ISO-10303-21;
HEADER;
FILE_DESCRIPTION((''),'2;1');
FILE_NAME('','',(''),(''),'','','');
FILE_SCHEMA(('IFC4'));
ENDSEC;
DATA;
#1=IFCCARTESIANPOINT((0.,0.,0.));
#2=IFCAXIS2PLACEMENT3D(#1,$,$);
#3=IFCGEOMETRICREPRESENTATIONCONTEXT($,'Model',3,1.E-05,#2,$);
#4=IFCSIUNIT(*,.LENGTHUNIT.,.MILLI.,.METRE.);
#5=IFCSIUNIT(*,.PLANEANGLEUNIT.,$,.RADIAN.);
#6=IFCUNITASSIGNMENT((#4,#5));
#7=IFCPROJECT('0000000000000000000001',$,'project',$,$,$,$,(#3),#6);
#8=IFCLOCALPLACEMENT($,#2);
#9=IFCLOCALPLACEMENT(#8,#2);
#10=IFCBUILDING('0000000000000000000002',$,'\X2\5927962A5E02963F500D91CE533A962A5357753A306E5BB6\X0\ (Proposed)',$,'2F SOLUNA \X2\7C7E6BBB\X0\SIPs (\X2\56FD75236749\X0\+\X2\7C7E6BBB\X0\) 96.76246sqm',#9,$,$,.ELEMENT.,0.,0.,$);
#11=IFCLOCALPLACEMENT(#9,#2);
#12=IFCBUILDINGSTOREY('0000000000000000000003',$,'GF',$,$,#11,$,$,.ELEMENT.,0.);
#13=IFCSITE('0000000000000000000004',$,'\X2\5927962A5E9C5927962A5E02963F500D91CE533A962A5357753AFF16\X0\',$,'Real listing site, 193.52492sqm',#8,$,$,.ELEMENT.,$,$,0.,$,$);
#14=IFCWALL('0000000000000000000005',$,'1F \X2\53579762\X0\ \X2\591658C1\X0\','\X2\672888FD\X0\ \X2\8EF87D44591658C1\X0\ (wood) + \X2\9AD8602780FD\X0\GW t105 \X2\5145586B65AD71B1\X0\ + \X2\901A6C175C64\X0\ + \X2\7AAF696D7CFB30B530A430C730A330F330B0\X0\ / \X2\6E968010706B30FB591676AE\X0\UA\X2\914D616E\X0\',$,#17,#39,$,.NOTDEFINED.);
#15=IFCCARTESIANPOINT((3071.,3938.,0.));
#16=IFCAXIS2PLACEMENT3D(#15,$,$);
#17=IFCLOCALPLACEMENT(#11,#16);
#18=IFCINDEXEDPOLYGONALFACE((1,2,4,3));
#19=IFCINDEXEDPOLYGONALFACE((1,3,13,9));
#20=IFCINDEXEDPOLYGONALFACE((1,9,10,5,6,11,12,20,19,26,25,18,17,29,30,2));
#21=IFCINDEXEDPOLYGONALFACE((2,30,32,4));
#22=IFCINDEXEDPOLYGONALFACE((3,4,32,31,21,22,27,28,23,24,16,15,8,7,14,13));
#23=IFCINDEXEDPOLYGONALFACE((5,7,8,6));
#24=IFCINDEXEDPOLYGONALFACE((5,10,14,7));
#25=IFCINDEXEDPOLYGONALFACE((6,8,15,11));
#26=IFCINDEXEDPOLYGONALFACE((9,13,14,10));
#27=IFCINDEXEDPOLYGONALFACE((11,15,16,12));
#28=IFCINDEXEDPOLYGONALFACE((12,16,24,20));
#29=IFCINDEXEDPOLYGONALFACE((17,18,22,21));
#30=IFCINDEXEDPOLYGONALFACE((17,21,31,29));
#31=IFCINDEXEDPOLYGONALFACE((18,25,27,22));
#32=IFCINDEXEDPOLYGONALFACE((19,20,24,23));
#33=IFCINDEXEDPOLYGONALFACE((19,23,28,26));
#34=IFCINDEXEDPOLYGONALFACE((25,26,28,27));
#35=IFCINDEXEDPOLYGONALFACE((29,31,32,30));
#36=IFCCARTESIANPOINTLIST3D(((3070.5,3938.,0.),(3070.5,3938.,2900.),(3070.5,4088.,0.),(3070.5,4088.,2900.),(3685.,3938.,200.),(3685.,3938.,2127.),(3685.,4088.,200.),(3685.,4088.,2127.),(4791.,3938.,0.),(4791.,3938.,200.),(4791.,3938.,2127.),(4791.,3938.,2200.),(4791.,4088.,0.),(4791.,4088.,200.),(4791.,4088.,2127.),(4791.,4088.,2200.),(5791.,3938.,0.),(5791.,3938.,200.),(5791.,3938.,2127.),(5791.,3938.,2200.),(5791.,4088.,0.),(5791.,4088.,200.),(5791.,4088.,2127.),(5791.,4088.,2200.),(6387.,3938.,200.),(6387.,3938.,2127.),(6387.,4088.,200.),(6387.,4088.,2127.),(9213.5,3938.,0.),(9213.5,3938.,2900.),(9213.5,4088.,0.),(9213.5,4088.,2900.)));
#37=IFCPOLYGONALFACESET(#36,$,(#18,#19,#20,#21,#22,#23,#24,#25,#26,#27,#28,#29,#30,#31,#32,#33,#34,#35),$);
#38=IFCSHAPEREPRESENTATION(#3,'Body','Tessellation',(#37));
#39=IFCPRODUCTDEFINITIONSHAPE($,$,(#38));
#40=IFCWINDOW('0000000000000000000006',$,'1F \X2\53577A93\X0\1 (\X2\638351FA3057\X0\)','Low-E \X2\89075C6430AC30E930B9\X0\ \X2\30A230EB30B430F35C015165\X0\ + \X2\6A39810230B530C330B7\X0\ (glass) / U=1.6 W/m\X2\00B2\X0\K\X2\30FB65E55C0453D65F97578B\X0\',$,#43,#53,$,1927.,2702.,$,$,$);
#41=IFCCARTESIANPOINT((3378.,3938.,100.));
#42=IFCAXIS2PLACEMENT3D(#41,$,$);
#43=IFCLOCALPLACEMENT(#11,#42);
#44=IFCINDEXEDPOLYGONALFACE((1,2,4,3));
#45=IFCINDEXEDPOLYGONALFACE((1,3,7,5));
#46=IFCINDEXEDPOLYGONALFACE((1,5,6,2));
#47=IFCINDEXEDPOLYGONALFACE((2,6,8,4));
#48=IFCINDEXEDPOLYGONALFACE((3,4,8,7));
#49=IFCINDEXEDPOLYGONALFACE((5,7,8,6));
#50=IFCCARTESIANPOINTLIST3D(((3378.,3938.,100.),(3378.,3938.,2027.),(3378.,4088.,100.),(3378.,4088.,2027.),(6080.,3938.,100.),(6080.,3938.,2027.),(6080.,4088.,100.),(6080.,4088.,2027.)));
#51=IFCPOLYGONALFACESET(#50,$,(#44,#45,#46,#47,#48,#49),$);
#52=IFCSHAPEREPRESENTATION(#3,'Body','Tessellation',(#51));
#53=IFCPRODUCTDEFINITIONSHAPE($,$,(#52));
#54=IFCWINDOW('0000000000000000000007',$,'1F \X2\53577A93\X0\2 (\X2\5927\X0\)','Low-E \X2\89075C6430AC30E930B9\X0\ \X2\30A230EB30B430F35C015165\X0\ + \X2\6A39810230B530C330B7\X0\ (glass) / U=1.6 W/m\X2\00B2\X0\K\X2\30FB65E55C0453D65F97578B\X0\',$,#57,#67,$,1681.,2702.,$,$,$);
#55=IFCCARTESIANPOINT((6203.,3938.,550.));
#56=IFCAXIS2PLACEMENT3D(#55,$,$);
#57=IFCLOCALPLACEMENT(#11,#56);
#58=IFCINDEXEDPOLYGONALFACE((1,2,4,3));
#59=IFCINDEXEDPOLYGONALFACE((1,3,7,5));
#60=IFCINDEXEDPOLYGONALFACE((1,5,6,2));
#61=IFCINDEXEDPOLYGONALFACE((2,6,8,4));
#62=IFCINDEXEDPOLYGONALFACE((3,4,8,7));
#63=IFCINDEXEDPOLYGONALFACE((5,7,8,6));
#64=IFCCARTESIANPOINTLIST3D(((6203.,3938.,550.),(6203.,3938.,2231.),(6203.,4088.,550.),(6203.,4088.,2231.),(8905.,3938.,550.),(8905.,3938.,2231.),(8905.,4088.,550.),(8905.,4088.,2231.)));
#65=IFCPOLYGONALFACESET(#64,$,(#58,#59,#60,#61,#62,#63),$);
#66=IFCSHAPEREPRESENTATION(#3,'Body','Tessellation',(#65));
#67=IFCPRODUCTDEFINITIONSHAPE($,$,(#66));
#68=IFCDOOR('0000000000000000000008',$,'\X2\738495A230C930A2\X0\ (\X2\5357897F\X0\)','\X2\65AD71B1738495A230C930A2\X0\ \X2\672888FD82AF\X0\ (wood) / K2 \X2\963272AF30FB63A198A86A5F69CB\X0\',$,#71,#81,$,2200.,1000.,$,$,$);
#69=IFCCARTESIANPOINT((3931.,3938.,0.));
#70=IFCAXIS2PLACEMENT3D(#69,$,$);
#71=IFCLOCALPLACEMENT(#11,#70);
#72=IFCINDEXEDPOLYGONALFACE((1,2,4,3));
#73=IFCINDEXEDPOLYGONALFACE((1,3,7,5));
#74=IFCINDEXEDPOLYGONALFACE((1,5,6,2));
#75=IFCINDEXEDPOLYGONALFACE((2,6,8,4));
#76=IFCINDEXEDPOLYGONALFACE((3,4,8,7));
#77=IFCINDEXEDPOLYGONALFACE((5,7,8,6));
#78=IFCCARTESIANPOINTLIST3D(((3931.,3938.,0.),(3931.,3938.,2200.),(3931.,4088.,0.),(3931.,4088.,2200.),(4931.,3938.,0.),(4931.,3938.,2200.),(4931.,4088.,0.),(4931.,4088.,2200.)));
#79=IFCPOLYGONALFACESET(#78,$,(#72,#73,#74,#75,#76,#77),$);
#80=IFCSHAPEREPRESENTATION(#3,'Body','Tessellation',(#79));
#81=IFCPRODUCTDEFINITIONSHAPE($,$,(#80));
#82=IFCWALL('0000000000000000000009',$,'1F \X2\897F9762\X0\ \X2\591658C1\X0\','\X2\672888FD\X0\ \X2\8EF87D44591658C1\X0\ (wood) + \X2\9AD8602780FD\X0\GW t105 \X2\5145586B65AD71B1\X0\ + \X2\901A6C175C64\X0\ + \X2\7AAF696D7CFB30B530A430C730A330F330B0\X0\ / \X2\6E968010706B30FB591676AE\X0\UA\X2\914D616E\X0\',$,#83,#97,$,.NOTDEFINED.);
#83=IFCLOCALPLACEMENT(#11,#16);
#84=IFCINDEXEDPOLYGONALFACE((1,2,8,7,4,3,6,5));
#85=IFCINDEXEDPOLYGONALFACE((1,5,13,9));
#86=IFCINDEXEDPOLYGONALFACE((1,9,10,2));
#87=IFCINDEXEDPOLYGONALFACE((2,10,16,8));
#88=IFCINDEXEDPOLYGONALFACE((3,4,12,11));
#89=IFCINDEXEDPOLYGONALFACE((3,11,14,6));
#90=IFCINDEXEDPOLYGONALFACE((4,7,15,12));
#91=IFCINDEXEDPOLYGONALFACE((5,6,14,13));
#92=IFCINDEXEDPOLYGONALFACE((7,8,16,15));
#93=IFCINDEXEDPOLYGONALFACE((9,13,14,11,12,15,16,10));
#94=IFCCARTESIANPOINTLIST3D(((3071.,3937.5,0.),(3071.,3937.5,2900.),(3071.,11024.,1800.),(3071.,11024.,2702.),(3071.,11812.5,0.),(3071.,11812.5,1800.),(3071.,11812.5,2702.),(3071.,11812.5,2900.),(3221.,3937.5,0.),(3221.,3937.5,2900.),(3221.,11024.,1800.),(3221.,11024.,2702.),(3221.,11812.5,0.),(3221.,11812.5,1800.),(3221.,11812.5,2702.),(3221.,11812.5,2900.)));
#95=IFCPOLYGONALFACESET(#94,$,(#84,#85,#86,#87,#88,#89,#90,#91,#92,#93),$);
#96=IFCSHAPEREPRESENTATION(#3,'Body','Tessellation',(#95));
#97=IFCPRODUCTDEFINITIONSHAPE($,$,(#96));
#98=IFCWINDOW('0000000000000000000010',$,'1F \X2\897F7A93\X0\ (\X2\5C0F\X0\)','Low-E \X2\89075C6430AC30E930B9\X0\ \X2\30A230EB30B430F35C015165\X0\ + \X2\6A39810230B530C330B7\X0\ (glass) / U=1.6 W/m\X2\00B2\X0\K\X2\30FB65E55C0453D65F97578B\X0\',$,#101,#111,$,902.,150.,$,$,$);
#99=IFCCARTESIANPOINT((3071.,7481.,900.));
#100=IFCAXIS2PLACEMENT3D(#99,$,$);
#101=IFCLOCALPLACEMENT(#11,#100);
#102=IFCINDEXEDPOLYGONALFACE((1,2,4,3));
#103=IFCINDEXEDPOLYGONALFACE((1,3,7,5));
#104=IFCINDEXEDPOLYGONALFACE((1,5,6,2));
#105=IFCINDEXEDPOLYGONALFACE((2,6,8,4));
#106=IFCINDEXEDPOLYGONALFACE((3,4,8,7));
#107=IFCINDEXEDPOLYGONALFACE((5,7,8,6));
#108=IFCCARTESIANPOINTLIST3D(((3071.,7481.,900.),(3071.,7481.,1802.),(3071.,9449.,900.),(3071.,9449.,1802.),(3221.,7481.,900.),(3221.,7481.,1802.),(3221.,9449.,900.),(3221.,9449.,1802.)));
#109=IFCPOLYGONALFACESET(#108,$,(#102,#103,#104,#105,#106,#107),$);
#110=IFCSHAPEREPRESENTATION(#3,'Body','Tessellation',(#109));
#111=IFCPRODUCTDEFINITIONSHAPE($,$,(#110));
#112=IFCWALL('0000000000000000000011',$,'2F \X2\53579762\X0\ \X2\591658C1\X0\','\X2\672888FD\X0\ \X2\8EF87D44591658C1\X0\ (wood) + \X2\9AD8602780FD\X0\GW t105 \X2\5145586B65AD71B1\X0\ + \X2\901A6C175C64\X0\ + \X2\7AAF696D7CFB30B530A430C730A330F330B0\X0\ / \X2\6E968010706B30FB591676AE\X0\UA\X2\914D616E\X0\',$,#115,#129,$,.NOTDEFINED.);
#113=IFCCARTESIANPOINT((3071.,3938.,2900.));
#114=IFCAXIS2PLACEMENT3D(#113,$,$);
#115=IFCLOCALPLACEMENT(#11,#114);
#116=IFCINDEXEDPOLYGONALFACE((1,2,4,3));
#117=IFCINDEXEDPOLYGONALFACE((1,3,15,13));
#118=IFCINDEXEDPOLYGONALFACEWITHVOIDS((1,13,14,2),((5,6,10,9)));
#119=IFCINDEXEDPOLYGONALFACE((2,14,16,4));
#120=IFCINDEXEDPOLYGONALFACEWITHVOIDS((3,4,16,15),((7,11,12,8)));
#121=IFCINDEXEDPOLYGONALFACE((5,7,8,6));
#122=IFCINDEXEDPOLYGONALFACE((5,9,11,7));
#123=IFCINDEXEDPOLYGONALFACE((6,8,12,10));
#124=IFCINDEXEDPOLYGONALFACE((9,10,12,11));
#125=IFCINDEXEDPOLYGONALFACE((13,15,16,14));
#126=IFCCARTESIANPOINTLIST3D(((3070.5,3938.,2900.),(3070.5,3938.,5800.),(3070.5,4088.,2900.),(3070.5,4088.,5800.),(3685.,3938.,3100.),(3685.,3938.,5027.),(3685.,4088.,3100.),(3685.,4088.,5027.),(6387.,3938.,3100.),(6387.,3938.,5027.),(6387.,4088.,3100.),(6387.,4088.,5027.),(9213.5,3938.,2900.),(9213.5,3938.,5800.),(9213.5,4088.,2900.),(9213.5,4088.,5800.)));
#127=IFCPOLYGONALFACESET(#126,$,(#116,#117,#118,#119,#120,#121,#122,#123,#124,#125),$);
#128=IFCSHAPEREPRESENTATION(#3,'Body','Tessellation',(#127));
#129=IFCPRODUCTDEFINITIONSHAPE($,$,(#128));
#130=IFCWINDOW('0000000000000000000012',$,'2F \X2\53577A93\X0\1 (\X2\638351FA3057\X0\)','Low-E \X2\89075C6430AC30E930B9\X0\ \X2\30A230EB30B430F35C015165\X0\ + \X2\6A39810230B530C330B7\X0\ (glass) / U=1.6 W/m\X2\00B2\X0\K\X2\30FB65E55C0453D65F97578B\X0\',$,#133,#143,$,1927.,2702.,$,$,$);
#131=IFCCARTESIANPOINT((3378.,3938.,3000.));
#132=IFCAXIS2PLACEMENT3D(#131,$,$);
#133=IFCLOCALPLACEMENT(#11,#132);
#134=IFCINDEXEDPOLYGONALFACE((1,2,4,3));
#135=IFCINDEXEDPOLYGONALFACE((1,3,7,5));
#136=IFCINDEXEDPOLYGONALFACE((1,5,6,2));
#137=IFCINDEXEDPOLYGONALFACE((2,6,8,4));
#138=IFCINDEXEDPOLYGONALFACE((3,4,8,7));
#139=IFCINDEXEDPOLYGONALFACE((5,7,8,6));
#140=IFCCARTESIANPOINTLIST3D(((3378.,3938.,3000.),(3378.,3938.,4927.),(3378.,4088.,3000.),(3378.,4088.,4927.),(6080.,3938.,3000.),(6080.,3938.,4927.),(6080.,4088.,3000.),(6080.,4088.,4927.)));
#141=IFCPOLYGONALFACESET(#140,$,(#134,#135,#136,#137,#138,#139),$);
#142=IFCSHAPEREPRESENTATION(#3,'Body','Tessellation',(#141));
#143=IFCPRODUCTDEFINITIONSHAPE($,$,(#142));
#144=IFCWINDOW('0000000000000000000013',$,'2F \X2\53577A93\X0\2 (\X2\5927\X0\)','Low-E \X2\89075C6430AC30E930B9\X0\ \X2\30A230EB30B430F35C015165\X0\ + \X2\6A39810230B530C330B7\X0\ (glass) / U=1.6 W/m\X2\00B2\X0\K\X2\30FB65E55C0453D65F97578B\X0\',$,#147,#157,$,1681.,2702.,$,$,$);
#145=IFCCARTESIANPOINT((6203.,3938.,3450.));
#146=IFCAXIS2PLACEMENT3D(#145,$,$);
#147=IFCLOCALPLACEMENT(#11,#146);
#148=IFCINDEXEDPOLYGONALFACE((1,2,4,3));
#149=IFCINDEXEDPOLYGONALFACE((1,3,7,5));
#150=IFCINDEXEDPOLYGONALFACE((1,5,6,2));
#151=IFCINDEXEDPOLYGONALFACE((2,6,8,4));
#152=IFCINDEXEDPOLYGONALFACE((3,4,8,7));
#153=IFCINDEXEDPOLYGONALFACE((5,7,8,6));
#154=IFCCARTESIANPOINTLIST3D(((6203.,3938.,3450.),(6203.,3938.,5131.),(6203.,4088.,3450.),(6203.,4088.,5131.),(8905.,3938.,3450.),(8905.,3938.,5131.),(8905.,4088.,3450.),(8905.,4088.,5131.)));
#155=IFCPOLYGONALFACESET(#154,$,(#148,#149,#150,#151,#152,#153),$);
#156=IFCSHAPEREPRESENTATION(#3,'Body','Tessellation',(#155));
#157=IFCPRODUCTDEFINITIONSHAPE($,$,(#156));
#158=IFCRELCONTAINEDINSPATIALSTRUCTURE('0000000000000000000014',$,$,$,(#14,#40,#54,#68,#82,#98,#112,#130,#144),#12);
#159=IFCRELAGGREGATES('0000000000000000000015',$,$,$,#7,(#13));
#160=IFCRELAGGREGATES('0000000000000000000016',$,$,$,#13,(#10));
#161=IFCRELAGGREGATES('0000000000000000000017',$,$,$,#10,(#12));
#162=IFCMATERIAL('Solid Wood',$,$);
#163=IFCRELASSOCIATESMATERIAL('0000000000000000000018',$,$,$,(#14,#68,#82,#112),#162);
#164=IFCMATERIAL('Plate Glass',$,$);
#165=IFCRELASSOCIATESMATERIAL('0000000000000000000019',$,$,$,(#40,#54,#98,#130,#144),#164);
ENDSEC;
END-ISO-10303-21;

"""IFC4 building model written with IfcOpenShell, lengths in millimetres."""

from ifc_helpers import new_model, si_unit, frame, frame_2d, origin, place, context, project, spatial, rectangle, extrude, material, element, fill, save


model = new_model("IFC4")

# Units and contexts
model_context = context("Model", 3, precision=1e-05, world=origin())
ifc_project = project(units=[si_unit("LENGTHUNIT", "METRE", prefix="MILLI"), si_unit("PLANEANGLEUNIT", "RADIAN")], contexts=[model_context])

# Site, building, storey
site_placement = place(None, origin())
site = spatial("IfcSite", under=ifc_project, at=site_placement, Name="大阪府大阪市阿倍野区阪南町６", ObjectType="Real listing site, 193.52492sqm", CompositionType="ELEMENT", RefElevation=0.0)
building_placement = place(site_placement, origin())
building = spatial("IfcBuilding", under=site, at=building_placement, Name="大阪市阿倍野区阪南町の家 (Proposed)", ObjectType="2F SOLUNA 籾殻SIPs (国産杉+籾殻) 96.76246sqm", CompositionType="ELEMENT", ElevationOfRefHeight=0.0, ElevationOfTerrain=0.0)
storey_placement = place(building_placement, origin())
storey = spatial("IfcBuildingStorey", under=building, at=storey_placement, Name="GF", CompositionType="ELEMENT", Elevation=0.0)

# Shared definitions
ifc_material_1 = material(Name="Solid Wood")

# Wall, openings, windows, door
wall_1_placement = place(storey_placement, frame((3071.0, 3938.0, 0.0)))
wall_1 = element("IfcWall", 1, at=wall_1_placement, inside=storey, material=ifc_material_1, Name="1F 南面 外壁", Description="木製 軸組外壁 (wood) + 高性能GW t105 充填断熱 + 通気層 + 窯業系サイディング / 準耐火・外皮UA配慮", PredefinedType="NOTDEFINED", context=model_context, shape_type="SweptSolid", body=[
    extrude(rectangle(XDim=6143.0, YDim=150.0, at=frame_2d((3071.0, 75.0))), frame((3071.0, 3938.0, 0.0)), (0.0, 0.0, 1.0), 2900.0),
])
opening_1_placement = place(storey_placement, frame((3378.0, 3938.0, 100.0)))
opening_1 = element("IfcOpeningElement", 2, at=opening_1_placement, cuts=wall_1, PredefinedType="NOTDEFINED", context=model_context, shape_type="SweptSolid", body=[
    extrude(rectangle(XDim=2702.0, YDim=150.0, at=frame_2d((1351.0, 75.0))), frame((3378.0, 3938.0, 100.0)), (0.0, 0.0, 1.0), 1927.0),
])
opening_2_placement = place(storey_placement, frame((6203.0, 3938.0, 550.0)))
opening_2 = element("IfcOpeningElement", 3, at=opening_2_placement, cuts=wall_1, PredefinedType="NOTDEFINED", context=model_context, shape_type="SweptSolid", body=[
    extrude(rectangle(XDim=2702.0, YDim=150.0, at=frame_2d((1351.0, 75.0))), frame((6203.0, 3938.0, 550.0)), (0.0, 0.0, 1.0), 1681.0),
])
opening_3_placement = place(storey_placement, frame((3931.0, 3938.0, 0.0)))
opening_3 = element("IfcOpeningElement", 4, at=opening_3_placement, cuts=wall_1, PredefinedType="NOTDEFINED", context=model_context, shape_type="SweptSolid", body=[
    extrude(rectangle(XDim=1000.0, YDim=150.0, at=frame_2d((500.0, 75.0))), frame((3931.0, 3938.0, 0.0)), (0.0, 0.0, 1.0), 2200.0),
])
ifc_material_2 = material(Name="Plate Glass")
window_1_placement = place(storey_placement, frame((3378.0, 3938.0, 100.0)))
window_1 = element("IfcWindow", 5, at=window_1_placement, inside=storey, material=ifc_material_2, Name="1F 南窓1 (掃出し)", Description="Low-E 複層ガラス アルゴン封入 + 樹脂サッシ (glass) / U=1.6 W/m²K・日射取得型", OverallHeight=1927.0, OverallWidth=2702.0, context=model_context, shape_type="SweptSolid", body=[
    extrude(rectangle(XDim=2702.0, YDim=150.0, at=frame_2d((1351.0, 75.0))), frame((3378.0, 3938.0, 100.0)), (0.0, 0.0, 1.0), 1927.0),
])
fill(opening_1, window_1)
window_2_placement = place(storey_placement, frame((6203.0, 3938.0, 550.0)))
window_2 = element("IfcWindow", 6, at=window_2_placement, inside=storey, material=ifc_material_2, Name="1F 南窓2 (大)", Description="Low-E 複層ガラス アルゴン封入 + 樹脂サッシ (glass) / U=1.6 W/m²K・日射取得型", OverallHeight=1681.0, OverallWidth=2702.0, context=model_context, shape_type="SweptSolid", body=[
    extrude(rectangle(XDim=2702.0, YDim=150.0, at=frame_2d((1351.0, 75.0))), frame((6203.0, 3938.0, 550.0)), (0.0, 0.0, 1.0), 1681.0),
])
fill(opening_2, window_2)
door_placement = place(storey_placement, frame((3931.0, 3938.0, 0.0)))
door = element("IfcDoor", 7, at=door_placement, inside=storey, material=ifc_material_1, Name="玄関ドア (南西)", Description="断熱玄関ドア 木製芯 (wood) / K2 防犯・採風機構", OverallHeight=2200.0, OverallWidth=1000.0, context=model_context, shape_type="SweptSolid", body=[
    extrude(rectangle(XDim=1000.0, YDim=150.0, at=frame_2d((500.0, 75.0))), frame((3931.0, 3938.0, 0.0)), (0.0, 0.0, 1.0), 2200.0),
])
fill(opening_3, door)

# Wall, opening, window
wall_2_placement = place(storey_placement, frame((3071.0, 3938.0, 0.0)))
wall_2 = element("IfcWall", 8, at=wall_2_placement, inside=storey, material=ifc_material_1, Name="1F 西面 外壁", Description="木製 軸組外壁 (wood) + 高性能GW t105 充填断熱 + 通気層 + 窯業系サイディング / 準耐火・外皮UA配慮", PredefinedType="NOTDEFINED", context=model_context, shape_type="SweptSolid", body=[
    extrude(rectangle(XDim=150.0, YDim=7875.0, at=frame_2d((75.0, 3937.0))), frame((3071.0, 3938.0, 0.0)), (0.0, 0.0, 1.0), 2900.0),
])
opening_4_placement = place(storey_placement, frame((3071.0, 7481.0, 900.0)))
opening_4 = element("IfcOpeningElement", 9, at=opening_4_placement, cuts=wall_2, PredefinedType="NOTDEFINED", context=model_context, shape_type="SweptSolid", body=[
    extrude(rectangle(XDim=150.0, YDim=1968.0, at=frame_2d((75.0, 984.0))), frame((3071.0, 7481.0, 900.0)), (0.0, 0.0, 1.0), 902.0),
])
window_3_placement = place(storey_placement, frame((3071.0, 7481.0, 900.0)))
window_3 = element("IfcWindow", 10, at=window_3_placement, inside=storey, material=ifc_material_2, Name="1F 西窓 (小)", Description="Low-E 複層ガラス アルゴン封入 + 樹脂サッシ (glass) / U=1.6 W/m²K・日射取得型", OverallHeight=902.0, OverallWidth=150.0, context=model_context, shape_type="SweptSolid", body=[
    extrude(rectangle(XDim=150.0, YDim=1968.0, at=frame_2d((75.0, 984.0))), frame((3071.0, 7481.0, 900.0)), (0.0, 0.0, 1.0), 902.0),
])
fill(opening_4, window_3)

# Wall, openings, windows
wall_3_placement = place(storey_placement, frame((3071.0, 3938.0, 2900.0)))
wall_3 = element("IfcWall", 11, at=wall_3_placement, inside=storey, material=ifc_material_1, Name="2F 南面 外壁", Description="木製 軸組外壁 (wood) + 高性能GW t105 充填断熱 + 通気層 + 窯業系サイディング / 準耐火・外皮UA配慮", PredefinedType="NOTDEFINED", context=model_context, shape_type="SweptSolid", body=[
    extrude(rectangle(XDim=6143.0, YDim=150.0, at=frame_2d((3071.0, 75.0))), frame((3071.0, 3938.0, 2900.0)), (0.0, 0.0, 1.0), 2900.0),
])
opening_5_placement = place(storey_placement, frame((3378.0, 3938.0, 3000.0)))
opening_5 = element("IfcOpeningElement", 12, at=opening_5_placement, cuts=wall_3, PredefinedType="NOTDEFINED", context=model_context, shape_type="SweptSolid", body=[
    extrude(rectangle(XDim=2702.0, YDim=150.0, at=frame_2d((1351.0, 75.0))), frame((3378.0, 3938.0, 3000.0)), (0.0, 0.0, 1.0), 1927.0),
])
opening_6_placement = place(storey_placement, frame((6203.0, 3938.0, 3450.0)))
opening_6 = element("IfcOpeningElement", 13, at=opening_6_placement, cuts=wall_3, PredefinedType="NOTDEFINED", context=model_context, shape_type="SweptSolid", body=[
    extrude(rectangle(XDim=2702.0, YDim=150.0, at=frame_2d((1351.0, 75.0))), frame((6203.0, 3938.0, 3450.0)), (0.0, 0.0, 1.0), 1681.0),
])
window_4_placement = place(storey_placement, frame((3378.0, 3938.0, 3000.0)))
window_4 = element("IfcWindow", 14, at=window_4_placement, inside=storey, material=ifc_material_2, Name="2F 南窓1 (掃出し)", Description="Low-E 複層ガラス アルゴン封入 + 樹脂サッシ (glass) / U=1.6 W/m²K・日射取得型", OverallHeight=1927.0, OverallWidth=2702.0, context=model_context, shape_type="SweptSolid", body=[
    extrude(rectangle(XDim=2702.0, YDim=150.0, at=frame_2d((1351.0, 75.0))), frame((3378.0, 3938.0, 3000.0)), (0.0, 0.0, 1.0), 1927.0),
])
fill(opening_5, window_4)
window_5_placement = place(storey_placement, frame((6203.0, 3938.0, 3450.0)))
window_5 = element("IfcWindow", 15, at=window_5_placement, inside=storey, material=ifc_material_2, Name="2F 南窓2 (大)", Description="Low-E 複層ガラス アルゴン封入 + 樹脂サッシ (glass) / U=1.6 W/m²K・日射取得型", OverallHeight=1681.0, OverallWidth=2702.0, context=model_context, shape_type="SweptSolid", body=[
    extrude(rectangle(XDim=2702.0, YDim=150.0, at=frame_2d((1351.0, 75.0))), frame((6203.0, 3938.0, 3450.0)), (0.0, 0.0, 1.0), 1681.0),
])
fill(opening_6, window_5)

save(model, "model.ifc")
